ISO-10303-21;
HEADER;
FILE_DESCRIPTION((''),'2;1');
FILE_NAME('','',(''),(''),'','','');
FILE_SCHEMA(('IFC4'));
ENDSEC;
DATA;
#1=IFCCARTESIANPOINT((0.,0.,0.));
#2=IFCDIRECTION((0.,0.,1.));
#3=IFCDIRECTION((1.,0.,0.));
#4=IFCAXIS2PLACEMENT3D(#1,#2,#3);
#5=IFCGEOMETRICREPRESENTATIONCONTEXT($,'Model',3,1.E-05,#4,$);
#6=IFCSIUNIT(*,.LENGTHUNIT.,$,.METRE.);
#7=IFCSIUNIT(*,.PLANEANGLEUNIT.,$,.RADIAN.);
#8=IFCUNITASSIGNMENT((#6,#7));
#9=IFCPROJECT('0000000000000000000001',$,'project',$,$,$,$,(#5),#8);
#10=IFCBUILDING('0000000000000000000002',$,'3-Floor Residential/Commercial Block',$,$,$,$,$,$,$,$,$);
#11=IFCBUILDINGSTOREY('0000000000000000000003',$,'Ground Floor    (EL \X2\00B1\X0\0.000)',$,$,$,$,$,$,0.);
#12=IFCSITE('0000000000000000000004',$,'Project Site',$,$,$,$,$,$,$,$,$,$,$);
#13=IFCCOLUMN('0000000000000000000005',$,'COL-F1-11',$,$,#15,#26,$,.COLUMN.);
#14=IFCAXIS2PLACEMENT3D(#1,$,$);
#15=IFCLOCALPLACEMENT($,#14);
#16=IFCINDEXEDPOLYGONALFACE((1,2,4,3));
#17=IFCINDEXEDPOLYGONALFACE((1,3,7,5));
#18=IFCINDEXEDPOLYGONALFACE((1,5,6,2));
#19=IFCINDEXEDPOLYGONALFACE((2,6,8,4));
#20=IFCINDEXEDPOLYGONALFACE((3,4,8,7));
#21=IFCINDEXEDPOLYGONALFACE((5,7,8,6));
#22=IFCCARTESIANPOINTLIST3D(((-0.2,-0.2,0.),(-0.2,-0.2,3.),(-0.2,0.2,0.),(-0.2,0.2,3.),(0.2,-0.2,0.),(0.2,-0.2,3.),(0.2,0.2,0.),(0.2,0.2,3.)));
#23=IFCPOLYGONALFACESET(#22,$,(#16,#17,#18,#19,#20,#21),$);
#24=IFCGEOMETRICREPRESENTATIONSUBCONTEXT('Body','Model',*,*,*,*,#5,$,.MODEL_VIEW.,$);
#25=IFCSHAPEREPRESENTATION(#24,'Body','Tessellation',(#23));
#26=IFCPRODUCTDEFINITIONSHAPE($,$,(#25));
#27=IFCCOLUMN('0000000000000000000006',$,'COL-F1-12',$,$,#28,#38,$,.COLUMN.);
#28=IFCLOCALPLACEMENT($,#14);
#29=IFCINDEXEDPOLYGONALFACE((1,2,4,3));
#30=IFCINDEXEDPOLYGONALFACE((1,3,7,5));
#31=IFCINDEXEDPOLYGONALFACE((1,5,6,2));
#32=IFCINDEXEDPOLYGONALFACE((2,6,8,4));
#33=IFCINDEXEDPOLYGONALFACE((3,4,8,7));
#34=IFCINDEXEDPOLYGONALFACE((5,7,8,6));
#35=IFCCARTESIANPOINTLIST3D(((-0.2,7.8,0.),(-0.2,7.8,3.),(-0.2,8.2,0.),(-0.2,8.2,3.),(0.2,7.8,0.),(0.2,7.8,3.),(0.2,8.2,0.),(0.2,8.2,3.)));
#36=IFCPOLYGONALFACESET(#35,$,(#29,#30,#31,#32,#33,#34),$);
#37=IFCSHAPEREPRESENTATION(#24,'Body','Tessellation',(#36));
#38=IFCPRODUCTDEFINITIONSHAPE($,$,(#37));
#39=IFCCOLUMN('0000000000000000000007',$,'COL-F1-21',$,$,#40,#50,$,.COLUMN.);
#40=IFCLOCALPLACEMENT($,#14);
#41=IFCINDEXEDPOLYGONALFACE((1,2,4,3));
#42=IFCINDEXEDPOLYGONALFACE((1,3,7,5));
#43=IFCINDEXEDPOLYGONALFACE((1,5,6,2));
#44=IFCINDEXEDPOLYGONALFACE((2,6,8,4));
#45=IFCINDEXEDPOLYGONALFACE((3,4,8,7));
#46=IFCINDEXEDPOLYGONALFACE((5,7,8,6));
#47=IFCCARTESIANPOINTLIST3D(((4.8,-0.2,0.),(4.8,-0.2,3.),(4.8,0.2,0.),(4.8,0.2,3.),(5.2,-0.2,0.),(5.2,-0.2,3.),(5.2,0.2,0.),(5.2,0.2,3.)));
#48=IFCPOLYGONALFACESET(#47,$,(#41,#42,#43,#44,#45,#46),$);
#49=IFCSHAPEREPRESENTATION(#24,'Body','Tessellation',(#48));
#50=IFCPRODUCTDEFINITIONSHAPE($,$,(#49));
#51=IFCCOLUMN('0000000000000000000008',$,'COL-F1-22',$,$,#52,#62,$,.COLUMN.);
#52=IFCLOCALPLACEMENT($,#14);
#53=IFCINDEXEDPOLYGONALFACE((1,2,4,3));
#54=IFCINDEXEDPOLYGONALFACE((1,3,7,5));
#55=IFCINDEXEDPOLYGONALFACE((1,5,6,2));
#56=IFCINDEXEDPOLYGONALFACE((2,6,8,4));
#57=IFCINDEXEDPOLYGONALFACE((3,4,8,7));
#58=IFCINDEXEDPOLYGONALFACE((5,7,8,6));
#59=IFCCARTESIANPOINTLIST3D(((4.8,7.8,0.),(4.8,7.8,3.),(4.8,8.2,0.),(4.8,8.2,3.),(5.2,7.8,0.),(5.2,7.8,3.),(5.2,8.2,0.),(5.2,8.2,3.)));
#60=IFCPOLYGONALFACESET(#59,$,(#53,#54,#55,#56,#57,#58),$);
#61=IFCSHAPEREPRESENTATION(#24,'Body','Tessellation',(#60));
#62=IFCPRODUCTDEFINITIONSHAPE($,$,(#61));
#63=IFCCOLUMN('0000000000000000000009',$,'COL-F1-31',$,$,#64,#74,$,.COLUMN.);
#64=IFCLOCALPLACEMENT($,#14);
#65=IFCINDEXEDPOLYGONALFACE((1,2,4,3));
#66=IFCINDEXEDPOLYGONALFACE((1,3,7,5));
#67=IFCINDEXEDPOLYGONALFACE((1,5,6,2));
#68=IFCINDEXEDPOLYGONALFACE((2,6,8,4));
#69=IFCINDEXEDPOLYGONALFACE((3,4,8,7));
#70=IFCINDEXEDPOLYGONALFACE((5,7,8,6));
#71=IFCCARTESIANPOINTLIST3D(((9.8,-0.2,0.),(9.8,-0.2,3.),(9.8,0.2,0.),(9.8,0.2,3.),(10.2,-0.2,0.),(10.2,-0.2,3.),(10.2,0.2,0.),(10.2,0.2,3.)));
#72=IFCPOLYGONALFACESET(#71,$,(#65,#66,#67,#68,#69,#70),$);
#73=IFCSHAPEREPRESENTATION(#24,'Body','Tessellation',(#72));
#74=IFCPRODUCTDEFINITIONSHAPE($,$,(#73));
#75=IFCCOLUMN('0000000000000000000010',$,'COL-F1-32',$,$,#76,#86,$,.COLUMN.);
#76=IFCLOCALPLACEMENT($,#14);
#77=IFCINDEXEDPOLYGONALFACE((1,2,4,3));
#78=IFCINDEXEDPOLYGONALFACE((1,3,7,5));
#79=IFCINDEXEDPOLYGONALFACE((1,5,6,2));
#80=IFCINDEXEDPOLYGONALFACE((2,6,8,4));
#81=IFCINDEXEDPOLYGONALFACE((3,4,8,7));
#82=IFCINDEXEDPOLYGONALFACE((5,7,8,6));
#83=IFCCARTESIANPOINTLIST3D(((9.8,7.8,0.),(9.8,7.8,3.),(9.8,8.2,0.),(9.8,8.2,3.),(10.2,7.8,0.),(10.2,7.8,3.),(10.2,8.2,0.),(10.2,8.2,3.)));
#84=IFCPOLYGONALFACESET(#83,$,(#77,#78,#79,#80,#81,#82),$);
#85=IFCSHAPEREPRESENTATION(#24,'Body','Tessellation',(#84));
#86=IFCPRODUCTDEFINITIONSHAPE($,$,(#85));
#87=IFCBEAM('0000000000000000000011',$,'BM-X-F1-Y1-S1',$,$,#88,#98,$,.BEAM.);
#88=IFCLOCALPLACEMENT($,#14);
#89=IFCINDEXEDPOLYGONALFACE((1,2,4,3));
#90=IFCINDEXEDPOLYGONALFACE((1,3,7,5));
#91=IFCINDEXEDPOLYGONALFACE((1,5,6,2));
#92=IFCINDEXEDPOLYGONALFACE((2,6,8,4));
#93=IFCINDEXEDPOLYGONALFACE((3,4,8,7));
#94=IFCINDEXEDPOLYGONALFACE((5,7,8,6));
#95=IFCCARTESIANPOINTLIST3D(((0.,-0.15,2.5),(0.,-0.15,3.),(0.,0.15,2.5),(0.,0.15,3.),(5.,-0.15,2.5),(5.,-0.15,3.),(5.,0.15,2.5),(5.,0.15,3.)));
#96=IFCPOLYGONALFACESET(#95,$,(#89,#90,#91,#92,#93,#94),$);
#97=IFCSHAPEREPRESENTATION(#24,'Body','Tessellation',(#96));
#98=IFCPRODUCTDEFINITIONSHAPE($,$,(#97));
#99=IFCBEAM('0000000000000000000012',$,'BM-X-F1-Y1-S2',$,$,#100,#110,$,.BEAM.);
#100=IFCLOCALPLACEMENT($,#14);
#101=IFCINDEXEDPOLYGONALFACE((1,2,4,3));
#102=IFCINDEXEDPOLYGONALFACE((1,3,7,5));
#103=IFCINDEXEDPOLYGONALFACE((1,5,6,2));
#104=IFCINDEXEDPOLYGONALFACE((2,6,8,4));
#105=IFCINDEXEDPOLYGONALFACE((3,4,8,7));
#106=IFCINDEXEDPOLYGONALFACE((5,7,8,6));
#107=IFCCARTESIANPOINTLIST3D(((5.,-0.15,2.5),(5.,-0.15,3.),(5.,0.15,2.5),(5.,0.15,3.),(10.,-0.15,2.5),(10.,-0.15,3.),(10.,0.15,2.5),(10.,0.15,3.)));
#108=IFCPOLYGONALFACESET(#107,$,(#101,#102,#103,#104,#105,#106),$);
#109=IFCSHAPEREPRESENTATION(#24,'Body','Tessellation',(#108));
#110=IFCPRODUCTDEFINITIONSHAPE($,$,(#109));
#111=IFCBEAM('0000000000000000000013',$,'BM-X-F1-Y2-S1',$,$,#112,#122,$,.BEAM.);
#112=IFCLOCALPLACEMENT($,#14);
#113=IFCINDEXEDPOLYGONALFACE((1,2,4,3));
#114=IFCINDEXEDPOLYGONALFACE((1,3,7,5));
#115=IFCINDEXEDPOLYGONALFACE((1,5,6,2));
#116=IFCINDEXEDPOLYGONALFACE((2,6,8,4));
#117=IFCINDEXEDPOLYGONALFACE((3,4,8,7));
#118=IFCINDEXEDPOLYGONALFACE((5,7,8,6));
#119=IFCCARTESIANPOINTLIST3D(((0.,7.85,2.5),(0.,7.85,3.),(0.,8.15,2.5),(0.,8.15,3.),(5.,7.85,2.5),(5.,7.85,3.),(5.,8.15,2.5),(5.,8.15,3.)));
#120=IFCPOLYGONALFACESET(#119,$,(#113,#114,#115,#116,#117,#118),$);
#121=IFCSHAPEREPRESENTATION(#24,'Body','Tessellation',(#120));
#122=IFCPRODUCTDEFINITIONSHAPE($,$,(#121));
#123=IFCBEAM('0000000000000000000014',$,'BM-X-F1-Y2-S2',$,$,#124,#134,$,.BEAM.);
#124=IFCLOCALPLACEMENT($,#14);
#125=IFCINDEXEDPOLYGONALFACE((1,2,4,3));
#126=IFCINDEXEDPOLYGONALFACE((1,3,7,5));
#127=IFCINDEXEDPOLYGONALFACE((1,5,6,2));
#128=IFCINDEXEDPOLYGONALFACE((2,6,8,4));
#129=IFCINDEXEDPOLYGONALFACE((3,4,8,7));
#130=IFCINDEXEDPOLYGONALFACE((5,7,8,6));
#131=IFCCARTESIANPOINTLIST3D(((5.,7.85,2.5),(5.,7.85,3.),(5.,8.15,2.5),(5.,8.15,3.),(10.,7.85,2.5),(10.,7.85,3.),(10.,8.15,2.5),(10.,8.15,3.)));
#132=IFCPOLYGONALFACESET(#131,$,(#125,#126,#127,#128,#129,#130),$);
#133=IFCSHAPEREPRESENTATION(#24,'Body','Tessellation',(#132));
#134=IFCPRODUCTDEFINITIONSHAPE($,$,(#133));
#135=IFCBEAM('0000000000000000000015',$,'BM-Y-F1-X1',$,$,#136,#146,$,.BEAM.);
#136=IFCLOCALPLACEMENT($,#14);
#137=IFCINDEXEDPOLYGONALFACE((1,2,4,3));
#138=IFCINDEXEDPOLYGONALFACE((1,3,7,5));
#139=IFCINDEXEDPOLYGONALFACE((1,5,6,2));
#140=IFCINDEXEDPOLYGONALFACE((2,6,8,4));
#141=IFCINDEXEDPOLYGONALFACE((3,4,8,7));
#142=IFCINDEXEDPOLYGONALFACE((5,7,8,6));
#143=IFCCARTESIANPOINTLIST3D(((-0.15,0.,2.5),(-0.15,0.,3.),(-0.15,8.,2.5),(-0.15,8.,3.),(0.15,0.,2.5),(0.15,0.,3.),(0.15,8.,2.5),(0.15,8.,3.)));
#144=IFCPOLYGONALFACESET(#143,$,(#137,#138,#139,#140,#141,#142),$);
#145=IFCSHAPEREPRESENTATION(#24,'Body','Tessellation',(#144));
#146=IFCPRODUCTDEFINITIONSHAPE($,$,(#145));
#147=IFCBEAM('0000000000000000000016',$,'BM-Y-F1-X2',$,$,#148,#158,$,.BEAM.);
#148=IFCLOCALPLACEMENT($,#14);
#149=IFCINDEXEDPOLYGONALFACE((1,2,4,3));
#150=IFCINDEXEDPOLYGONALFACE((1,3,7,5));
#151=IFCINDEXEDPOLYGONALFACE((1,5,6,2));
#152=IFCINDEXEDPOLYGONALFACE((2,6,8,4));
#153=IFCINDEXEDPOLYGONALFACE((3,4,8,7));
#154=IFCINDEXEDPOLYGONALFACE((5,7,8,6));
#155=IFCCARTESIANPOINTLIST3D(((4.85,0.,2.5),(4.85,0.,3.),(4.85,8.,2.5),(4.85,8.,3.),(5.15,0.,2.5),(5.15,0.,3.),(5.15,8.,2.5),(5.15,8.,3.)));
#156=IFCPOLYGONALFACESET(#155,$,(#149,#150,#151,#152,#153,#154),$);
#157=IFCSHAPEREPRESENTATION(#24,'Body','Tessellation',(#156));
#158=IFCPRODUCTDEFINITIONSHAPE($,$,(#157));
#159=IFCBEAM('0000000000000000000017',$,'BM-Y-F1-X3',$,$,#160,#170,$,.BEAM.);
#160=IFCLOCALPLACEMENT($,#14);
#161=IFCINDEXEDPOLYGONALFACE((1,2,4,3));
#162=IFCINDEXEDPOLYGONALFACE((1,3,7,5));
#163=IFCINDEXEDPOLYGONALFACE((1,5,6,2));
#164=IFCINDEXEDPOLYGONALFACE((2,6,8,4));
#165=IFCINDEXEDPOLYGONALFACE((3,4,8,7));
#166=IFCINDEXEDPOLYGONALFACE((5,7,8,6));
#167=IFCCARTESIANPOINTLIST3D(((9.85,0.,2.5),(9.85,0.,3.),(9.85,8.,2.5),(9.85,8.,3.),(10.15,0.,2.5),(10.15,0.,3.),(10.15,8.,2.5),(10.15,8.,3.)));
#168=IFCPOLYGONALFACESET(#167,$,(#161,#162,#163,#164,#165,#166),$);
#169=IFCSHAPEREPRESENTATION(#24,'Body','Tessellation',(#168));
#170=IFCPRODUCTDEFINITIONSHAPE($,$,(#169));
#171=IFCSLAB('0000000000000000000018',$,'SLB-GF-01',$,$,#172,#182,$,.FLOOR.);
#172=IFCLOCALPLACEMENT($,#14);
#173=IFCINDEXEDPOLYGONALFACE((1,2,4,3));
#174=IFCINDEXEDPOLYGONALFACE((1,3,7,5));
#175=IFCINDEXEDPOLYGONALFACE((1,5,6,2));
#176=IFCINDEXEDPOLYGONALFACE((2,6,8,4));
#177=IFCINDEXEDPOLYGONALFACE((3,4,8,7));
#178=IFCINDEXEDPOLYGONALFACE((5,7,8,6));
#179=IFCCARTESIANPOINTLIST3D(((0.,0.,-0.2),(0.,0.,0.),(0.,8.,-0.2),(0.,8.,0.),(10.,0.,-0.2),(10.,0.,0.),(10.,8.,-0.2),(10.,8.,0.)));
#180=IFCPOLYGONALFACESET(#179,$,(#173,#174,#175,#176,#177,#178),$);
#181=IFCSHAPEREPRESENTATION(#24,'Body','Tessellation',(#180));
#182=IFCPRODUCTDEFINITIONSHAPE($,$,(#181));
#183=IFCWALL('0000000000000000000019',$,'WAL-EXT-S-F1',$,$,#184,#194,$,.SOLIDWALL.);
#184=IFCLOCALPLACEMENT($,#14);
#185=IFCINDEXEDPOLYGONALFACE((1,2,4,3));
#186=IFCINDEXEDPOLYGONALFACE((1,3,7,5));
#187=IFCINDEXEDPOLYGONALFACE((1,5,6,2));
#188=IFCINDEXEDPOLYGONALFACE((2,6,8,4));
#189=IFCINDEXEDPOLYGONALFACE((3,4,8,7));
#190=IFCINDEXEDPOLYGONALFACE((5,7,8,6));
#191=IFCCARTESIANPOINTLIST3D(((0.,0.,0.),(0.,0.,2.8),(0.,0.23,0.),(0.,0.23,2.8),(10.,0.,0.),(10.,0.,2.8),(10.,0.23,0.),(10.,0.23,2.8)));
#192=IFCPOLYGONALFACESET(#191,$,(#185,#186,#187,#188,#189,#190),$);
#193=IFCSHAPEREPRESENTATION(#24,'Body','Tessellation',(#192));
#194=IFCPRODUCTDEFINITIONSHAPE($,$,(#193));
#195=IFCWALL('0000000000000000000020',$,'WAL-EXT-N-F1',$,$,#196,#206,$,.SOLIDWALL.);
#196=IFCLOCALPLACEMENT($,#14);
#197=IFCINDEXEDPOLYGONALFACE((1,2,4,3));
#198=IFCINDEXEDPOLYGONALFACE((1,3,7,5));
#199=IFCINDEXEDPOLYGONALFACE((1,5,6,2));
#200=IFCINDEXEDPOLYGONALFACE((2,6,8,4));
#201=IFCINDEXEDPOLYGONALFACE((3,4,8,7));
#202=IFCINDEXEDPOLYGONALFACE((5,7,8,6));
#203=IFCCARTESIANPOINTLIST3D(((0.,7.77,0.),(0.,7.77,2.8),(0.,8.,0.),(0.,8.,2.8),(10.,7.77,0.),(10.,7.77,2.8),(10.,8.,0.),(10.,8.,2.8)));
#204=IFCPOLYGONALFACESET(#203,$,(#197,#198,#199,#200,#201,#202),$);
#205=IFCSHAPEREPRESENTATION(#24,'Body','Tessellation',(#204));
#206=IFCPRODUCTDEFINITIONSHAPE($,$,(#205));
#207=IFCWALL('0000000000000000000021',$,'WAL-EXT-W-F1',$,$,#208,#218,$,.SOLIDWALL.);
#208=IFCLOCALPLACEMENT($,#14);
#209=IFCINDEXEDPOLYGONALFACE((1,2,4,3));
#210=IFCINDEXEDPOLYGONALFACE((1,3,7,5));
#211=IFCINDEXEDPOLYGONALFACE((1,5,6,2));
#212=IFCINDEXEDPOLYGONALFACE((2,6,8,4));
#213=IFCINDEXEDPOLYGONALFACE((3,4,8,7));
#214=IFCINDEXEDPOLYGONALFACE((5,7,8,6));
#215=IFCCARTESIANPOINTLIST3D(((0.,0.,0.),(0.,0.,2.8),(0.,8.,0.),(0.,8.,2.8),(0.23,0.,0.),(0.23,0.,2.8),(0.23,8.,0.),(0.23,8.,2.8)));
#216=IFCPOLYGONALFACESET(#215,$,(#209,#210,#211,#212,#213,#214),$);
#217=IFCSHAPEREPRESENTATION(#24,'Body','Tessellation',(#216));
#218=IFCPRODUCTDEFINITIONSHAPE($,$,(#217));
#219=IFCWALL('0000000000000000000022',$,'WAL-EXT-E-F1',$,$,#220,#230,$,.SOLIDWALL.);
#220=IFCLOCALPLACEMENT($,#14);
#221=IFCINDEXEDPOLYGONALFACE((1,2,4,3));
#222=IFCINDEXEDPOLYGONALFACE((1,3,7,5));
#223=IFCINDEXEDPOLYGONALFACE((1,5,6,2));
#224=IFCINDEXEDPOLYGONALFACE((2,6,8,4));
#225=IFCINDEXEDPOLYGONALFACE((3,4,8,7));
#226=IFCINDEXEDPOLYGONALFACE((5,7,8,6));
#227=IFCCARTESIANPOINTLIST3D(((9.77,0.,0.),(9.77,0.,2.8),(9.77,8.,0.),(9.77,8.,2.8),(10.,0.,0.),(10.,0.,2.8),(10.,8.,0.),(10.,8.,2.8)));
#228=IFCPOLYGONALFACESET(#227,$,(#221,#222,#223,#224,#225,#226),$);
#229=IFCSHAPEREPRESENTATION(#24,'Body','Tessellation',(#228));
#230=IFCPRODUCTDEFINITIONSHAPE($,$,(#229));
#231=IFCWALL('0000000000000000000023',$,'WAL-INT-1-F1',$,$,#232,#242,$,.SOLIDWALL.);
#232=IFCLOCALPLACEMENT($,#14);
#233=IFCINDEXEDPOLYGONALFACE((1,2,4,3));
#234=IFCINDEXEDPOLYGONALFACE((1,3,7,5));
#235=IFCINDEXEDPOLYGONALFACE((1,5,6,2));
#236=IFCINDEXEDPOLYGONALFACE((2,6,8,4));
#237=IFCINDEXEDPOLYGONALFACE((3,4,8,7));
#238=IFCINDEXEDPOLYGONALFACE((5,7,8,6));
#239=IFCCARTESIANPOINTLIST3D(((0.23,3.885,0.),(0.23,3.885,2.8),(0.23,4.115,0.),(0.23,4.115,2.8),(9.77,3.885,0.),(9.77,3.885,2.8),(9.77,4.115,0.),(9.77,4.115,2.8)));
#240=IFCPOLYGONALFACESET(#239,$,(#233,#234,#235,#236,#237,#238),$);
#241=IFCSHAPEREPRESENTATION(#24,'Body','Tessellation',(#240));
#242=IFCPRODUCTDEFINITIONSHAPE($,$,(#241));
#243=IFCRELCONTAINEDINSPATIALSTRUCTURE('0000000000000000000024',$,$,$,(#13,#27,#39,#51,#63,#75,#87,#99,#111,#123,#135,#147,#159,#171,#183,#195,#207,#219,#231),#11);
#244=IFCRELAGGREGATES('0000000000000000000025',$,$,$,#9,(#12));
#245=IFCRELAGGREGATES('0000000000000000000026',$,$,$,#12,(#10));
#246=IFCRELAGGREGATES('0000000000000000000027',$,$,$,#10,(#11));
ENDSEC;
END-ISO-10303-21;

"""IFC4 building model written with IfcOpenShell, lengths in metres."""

from ifc_helpers import new_model, si_unit, frame, frame_2d, origin_with_axes, place, context, subcontext, project, spatial, rectangle, extrude, element, save


model = new_model("IFC4")

# Units and contexts
model_context = context("Model", 3, precision=1e-05, world=origin_with_axes())
body_context = subcontext(model_context, "Body", "Model", "MODEL_VIEW")
ifc_project = project(units=[si_unit("LENGTHUNIT", "METRE"), si_unit("PLANEANGLEUNIT", "RADIAN")], contexts=[model_context])

# Site, building, storey
site = spatial("IfcSite", under=ifc_project, Name="Project Site")
building = spatial("IfcBuilding", under=site, Name="3-Floor Residential/Commercial Block")
storey = spatial("IfcBuildingStorey", under=building, Name="Ground Floor    (EL ±0.000)", Elevation=0.0)

# Columns
for number, where, z_axis, x_axis, name in (
    (1, (-0.2, -0.2, 0.0), (0.0, 0.0, 1.0), (1.0, 0.0, 0.0), "COL-F1-11"),
    (2, (-0.2, 7.8, 0.0), (0.0, 0.0, 1.0), (1.0, 0.0, 0.0), "COL-F1-12"),
    (3, (4.8, -0.2, 0.0), (0.0, 0.0, 1.0), (1.0, 0.0, 0.0), "COL-F1-21"),
    (4, (4.8, 7.8, 0.0), (0.0, 0.0, 1.0), (1.0, 0.0, 0.0), "COL-F1-22"),
    (5, (9.8, -0.2, 0.0), (0.0, 0.0, 1.0), (1.0, 0.0, 0.0), "COL-F1-31"),
    (6, (9.8, 7.8, 0.0), (0.0, 0.0, 1.0), (1.0, 0.0, 0.0), "COL-F1-32"),
):
    element("IfcColumn", number, at=place(None, frame(where, z_axis=z_axis, x_axis=x_axis)), inside=storey, Name=name, PredefinedType="COLUMN", context=body_context, shape_type="SweptSolid", body=[
        extrude(rectangle(XDim=0.4, YDim=0.4, at=frame_2d((0.2, 0.2))), origin_with_axes(), (0.0, 0.0, 1.0), 3.0),
    ])

# Beams
for number, where, z_axis, x_axis, name in (
    (7, (0.0, -0.15, 2.5), (0.0, 0.0, 1.0), (1.0, 0.0, 0.0), "BM-X-F1-Y1-S1"),
    (8, (5.0, -0.15, 2.5), (0.0, 0.0, 1.0), (1.0, 0.0, 0.0), "BM-X-F1-Y1-S2"),
    (9, (0.0, 7.85, 2.5), (0.0, 0.0, 1.0), (1.0, 0.0, 0.0), "BM-X-F1-Y2-S1"),
    (10, (5.0, 7.85, 2.5), (0.0, 0.0, 1.0), (1.0, 0.0, 0.0), "BM-X-F1-Y2-S2"),
):
    element("IfcBeam", number, at=place(None, frame(where, z_axis=z_axis, x_axis=x_axis)), inside=storey, Name=name, PredefinedType="BEAM", context=body_context, shape_type="SweptSolid", body=[
        extrude(rectangle(XDim=5.0, YDim=0.3, at=frame_2d((2.5, 0.15))), origin_with_axes(), (0.0, 0.0, 1.0), 0.5),
    ])
for number, where, z_axis, x_axis, name in (
    (11, (-0.15, 0.0, 2.5), (0.0, 0.0, 1.0), (1.0, 0.0, 0.0), "BM-Y-F1-X1"),
    (12, (4.85, 0.0, 2.5), (0.0, 0.0, 1.0), (1.0, 0.0, 0.0), "BM-Y-F1-X2"),
    (13, (9.85, 0.0, 2.5), (0.0, 0.0, 1.0), (1.0, 0.0, 0.0), "BM-Y-F1-X3"),
):
    element("IfcBeam", number, at=place(None, frame(where, z_axis=z_axis, x_axis=x_axis)), inside=storey, Name=name, PredefinedType="BEAM", context=body_context, shape_type="SweptSolid", body=[
        extrude(rectangle(XDim=0.3, YDim=8.0, at=frame_2d((0.15, 4.0))), origin_with_axes(), (0.0, 0.0, 1.0), 0.5),
    ])

# Slab
slab_placement = place(None, frame((0.0, 0.0, -0.2), z_axis=(0.0, 0.0, 1.0), x_axis=(1.0, 0.0, 0.0)))
element("IfcSlab", 14, at=slab_placement, inside=storey, Name="SLB-GF-01", PredefinedType="FLOOR", context=body_context, shape_type="SweptSolid", body=[
    extrude(rectangle(XDim=10.0, YDim=8.0, at=frame_2d((5.0, 4.0))), origin_with_axes(), (0.0, 0.0, 1.0), 0.2),
])

# Walls
for number, where, z_axis, x_axis, name in (
    (15, (0.0, 0.0, 0.0), (0.0, 0.0, 1.0), (1.0, 0.0, 0.0), "WAL-EXT-S-F1"),
    (16, (0.0, 7.77, 0.0), (0.0, 0.0, 1.0), (1.0, 0.0, 0.0), "WAL-EXT-N-F1"),
):
    element("IfcWall", number, at=place(None, frame(where, z_axis=z_axis, x_axis=x_axis)), inside=storey, Name=name, PredefinedType="SOLIDWALL", context=body_context, shape_type="SweptSolid", body=[
        extrude(rectangle(XDim=10.0, YDim=0.23, at=frame_2d((5.0, 0.115))), origin_with_axes(), (0.0, 0.0, 1.0), 2.8),
    ])
for number, where, z_axis, x_axis, name in (
    (17, (0.0, 0.0, 0.0), (0.0, 0.0, 1.0), (1.0, 0.0, 0.0), "WAL-EXT-W-F1"),
    (18, (9.77, 0.0, 0.0), (0.0, 0.0, 1.0), (1.0, 0.0, 0.0), "WAL-EXT-E-F1"),
):
    element("IfcWall", number, at=place(None, frame(where, z_axis=z_axis, x_axis=x_axis)), inside=storey, Name=name, PredefinedType="SOLIDWALL", context=body_context, shape_type="SweptSolid", body=[
        extrude(rectangle(XDim=0.23, YDim=8.0, at=frame_2d((0.115, 4.0))), origin_with_axes(), (0.0, 0.0, 1.0), 2.8),
    ])
wall_1_placement = place(None, frame((0.23, 3.885, 0.0), z_axis=(0.0, 0.0, 1.0), x_axis=(1.0, 0.0, 0.0)))
element("IfcWall", 19, at=wall_1_placement, inside=storey, Name="WAL-INT-1-F1", PredefinedType="SOLIDWALL", context=body_context, shape_type="SweptSolid", body=[
    extrude(rectangle(XDim=9.54, YDim=0.23, at=frame_2d((4.77, 0.115))), origin_with_axes(), (0.0, 0.0, 1.0), 2.8),
])

save(model, "model.ifc")
